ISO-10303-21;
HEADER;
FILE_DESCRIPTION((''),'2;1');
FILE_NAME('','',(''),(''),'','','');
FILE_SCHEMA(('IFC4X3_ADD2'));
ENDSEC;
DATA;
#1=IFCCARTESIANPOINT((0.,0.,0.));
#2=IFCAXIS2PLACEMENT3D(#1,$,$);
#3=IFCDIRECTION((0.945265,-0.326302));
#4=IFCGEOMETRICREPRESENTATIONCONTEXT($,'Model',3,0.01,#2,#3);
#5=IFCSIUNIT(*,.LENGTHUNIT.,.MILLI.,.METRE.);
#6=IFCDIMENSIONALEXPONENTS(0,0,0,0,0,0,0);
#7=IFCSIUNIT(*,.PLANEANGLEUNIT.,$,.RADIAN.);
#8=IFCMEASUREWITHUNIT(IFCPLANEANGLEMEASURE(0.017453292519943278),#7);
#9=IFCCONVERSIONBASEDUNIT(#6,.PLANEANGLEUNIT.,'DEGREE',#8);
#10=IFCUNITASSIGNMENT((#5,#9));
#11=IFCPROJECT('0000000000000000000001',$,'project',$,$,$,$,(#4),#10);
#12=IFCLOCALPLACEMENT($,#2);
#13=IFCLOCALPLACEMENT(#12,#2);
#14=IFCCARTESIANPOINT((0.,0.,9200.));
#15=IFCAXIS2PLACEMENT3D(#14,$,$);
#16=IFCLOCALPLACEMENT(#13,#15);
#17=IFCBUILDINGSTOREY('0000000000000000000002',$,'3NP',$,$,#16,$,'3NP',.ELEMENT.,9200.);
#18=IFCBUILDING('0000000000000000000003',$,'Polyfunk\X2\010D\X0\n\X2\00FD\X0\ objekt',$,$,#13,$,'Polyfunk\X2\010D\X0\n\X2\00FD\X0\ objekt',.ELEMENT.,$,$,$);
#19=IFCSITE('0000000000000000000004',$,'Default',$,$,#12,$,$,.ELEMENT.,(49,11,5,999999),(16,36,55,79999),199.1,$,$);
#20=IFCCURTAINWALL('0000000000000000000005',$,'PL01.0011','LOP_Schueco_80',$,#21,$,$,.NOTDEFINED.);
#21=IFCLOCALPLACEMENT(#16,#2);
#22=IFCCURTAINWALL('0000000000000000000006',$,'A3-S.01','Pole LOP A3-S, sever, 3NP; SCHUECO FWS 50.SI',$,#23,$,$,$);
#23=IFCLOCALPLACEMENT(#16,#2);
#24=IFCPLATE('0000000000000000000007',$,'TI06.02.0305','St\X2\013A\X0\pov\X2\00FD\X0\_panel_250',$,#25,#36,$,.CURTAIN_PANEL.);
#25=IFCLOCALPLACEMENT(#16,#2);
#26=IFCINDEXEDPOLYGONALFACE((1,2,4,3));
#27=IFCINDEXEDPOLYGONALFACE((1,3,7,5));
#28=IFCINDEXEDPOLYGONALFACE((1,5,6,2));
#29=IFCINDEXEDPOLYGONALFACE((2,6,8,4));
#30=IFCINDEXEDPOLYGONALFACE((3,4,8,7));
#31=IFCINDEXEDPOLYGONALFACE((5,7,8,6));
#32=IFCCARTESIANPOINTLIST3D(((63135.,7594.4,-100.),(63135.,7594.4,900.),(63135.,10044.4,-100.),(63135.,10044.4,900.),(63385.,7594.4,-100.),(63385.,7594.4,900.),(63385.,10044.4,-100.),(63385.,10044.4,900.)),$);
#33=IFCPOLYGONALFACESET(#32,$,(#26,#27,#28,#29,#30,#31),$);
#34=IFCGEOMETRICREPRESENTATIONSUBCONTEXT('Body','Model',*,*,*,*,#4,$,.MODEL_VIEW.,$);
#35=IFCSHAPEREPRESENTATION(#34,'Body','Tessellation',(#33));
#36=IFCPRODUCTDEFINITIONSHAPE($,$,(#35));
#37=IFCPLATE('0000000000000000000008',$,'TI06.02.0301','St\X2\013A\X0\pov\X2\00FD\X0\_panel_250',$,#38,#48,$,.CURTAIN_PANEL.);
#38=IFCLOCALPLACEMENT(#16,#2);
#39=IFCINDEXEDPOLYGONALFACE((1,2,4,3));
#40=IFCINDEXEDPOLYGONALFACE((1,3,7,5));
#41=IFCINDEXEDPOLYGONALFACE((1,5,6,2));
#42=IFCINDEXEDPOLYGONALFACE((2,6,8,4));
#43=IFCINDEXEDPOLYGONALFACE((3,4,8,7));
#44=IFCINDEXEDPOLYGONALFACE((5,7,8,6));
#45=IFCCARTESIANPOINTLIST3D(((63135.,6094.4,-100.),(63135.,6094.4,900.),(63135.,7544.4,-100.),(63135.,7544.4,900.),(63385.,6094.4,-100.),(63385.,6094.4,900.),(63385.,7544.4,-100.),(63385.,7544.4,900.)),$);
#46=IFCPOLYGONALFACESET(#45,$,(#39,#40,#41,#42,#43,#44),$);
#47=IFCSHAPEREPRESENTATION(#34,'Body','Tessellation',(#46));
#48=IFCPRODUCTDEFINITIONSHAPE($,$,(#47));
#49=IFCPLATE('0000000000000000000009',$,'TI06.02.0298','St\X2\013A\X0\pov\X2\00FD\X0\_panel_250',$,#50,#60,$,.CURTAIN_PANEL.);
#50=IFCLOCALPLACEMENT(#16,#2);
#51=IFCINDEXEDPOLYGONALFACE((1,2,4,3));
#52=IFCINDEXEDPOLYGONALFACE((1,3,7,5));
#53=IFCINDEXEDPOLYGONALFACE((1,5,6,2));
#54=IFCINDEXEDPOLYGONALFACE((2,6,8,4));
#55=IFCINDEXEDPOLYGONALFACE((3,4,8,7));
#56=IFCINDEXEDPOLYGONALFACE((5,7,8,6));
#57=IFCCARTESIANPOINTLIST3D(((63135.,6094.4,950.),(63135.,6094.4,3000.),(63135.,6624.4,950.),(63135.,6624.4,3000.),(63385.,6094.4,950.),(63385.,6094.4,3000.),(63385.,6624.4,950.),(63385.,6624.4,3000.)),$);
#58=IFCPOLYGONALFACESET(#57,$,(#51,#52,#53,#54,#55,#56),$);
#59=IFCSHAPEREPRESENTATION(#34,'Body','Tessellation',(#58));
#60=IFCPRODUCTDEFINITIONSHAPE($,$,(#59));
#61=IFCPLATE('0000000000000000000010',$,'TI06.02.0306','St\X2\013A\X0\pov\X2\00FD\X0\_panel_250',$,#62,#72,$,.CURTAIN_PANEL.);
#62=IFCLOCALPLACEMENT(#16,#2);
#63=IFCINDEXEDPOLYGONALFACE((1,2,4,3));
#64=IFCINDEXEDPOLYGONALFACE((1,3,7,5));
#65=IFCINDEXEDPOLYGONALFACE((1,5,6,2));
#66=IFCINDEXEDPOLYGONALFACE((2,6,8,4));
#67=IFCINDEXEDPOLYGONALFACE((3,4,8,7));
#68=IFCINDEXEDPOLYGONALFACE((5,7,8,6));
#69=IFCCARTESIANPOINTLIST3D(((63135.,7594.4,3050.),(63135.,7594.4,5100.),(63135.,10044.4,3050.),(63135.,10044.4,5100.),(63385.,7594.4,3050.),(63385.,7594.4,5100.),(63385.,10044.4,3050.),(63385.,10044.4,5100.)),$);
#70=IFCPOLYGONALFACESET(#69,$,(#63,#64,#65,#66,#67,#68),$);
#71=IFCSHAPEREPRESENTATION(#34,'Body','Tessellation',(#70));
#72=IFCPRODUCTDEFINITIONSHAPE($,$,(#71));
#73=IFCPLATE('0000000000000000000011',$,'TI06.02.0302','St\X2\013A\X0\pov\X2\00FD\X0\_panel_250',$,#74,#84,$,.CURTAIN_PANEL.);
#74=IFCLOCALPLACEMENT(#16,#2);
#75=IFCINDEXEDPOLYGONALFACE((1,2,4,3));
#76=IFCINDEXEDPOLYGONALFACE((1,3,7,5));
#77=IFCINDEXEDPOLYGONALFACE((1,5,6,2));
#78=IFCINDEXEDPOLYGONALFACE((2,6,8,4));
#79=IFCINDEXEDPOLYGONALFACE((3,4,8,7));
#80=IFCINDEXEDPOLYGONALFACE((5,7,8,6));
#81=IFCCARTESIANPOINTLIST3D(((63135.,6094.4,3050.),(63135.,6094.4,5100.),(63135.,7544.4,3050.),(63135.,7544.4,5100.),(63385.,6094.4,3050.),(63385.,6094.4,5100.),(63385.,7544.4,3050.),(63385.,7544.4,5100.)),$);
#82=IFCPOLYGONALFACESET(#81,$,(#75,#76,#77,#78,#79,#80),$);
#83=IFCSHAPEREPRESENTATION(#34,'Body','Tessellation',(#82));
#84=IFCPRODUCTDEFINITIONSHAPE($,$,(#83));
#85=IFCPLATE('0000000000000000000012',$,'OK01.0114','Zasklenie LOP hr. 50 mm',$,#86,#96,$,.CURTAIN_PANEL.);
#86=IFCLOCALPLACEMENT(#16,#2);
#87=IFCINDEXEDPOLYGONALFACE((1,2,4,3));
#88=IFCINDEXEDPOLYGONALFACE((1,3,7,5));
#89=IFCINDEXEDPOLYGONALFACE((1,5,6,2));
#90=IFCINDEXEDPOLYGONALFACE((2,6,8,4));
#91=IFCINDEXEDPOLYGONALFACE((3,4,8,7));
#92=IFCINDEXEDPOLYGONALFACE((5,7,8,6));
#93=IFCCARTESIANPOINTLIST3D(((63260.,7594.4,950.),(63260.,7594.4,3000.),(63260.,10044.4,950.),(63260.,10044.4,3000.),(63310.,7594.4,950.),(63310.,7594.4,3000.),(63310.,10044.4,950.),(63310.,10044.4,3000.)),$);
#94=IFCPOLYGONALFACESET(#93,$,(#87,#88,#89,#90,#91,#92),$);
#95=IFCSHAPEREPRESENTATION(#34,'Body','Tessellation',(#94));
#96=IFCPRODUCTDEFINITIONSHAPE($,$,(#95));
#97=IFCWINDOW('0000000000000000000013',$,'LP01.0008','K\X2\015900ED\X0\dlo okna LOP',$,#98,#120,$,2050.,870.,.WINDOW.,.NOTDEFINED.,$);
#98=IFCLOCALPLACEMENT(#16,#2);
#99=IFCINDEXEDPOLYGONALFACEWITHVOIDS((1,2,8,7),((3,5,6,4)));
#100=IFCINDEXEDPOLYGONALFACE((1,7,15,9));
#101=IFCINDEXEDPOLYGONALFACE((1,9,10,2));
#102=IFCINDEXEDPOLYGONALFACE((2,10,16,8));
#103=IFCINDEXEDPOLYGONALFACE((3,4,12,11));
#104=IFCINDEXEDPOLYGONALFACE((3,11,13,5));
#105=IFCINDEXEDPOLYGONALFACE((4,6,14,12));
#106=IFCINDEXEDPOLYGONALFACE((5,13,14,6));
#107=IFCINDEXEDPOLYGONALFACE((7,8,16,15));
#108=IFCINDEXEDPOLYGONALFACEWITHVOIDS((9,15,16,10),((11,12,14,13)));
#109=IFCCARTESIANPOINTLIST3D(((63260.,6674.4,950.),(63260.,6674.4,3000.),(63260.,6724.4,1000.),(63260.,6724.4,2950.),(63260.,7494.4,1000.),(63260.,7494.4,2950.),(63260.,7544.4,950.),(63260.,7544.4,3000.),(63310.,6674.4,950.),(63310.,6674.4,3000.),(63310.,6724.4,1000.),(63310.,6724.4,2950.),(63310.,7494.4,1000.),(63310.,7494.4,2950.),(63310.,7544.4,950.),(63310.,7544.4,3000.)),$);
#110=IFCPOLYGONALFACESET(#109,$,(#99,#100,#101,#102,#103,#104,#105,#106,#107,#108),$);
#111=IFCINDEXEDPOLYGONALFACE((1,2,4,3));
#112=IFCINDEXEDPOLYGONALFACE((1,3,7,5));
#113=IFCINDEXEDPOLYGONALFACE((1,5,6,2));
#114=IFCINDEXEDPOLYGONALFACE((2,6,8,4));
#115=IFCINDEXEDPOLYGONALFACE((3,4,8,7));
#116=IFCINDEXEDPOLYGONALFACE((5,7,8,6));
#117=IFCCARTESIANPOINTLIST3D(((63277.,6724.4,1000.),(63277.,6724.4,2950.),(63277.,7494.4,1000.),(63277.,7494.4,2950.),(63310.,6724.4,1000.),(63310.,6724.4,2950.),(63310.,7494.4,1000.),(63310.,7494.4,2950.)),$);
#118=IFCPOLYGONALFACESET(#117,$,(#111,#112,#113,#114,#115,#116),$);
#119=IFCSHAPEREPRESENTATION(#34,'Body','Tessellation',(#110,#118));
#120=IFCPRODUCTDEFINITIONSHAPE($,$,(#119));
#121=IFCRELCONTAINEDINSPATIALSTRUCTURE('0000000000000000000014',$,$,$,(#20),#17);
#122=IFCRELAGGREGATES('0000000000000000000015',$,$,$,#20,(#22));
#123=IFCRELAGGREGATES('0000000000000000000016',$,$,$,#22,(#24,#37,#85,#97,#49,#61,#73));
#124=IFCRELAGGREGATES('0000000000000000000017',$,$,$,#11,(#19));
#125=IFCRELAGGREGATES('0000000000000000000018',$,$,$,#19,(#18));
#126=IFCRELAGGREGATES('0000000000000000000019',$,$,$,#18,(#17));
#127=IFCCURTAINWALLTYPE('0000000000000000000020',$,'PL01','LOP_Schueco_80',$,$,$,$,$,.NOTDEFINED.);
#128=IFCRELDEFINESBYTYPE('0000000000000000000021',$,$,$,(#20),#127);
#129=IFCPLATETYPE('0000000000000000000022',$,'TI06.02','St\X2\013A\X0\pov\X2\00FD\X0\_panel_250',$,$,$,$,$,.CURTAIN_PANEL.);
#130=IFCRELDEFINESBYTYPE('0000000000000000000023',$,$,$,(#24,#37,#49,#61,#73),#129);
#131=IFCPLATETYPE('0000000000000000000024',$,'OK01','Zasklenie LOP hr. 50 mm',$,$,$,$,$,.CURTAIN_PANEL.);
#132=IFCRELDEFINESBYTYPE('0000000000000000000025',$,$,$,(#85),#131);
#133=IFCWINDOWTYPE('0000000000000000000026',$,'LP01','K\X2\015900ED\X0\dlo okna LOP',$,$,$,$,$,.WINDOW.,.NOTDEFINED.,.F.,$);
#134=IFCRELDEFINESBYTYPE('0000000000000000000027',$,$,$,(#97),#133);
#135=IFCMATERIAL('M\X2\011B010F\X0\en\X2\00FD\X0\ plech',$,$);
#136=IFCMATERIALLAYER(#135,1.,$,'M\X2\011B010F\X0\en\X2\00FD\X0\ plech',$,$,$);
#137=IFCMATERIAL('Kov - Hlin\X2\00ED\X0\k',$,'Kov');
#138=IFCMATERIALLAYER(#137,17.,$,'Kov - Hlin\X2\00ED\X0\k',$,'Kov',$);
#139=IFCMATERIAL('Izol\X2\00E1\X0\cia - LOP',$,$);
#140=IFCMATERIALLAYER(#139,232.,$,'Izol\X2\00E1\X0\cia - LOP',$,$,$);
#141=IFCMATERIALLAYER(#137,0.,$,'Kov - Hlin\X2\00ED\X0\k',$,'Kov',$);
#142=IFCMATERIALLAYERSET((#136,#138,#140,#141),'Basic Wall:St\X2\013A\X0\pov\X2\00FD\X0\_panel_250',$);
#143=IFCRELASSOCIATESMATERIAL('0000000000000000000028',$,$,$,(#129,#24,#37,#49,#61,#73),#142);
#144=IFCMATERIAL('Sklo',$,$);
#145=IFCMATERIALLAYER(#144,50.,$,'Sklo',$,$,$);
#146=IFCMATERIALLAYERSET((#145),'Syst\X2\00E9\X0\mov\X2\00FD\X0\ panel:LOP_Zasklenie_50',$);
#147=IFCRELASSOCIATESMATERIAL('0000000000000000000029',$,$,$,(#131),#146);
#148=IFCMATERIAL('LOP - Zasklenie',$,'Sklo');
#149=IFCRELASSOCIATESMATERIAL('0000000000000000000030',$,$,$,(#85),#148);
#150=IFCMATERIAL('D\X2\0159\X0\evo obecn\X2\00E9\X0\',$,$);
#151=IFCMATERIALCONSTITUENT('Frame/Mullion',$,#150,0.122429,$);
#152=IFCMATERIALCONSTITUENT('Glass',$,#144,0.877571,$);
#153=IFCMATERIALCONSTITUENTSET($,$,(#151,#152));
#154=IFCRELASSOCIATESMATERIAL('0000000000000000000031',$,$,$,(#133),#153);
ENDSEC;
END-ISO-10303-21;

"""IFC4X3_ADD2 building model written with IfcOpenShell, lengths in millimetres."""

from ifc_helpers import new_model, entity, si_unit, converted_unit, direction, frame, frame_2d, origin, origin_2d_with_axis, place, context, subcontext, project, spatial, polyline, rectangle, outline, extrude, source, transform, mapped, material, layer, layer_set, layer_usage, constituent, constituent_set, type_object, type_shapes, element, aggregate, save


model = new_model("IFC4X3_ADD2")

# Units and contexts
model_context = context("Model", 3, precision=0.01, world=origin(), true_north=direction((0.945265, -0.326302)))
body_context = subcontext(model_context, "Body", "Model", "MODEL_VIEW")
ifc_project = project(units=[si_unit("LENGTHUNIT", "METRE", prefix="MILLI"), converted_unit("PLANEANGLEUNIT", "DEGREE", entity("IfcPlaneAngleMeasure", 0.017453292519943278), si_unit("PLANEANGLEUNIT", "RADIAN"), dimensions=[0, 0, 0, 0, 0, 0, 0])], contexts=[model_context])

# Site, building, storey
site_placement = place(None, origin())
site = spatial("IfcSite", under=ifc_project, at=site_placement, Name="Default", CompositionType="ELEMENT", RefLatitude=(49, 11, 5, 999999), RefLongitude=(16, 36, 55, 79999), RefElevation=199.1)
building_placement = place(site_placement, origin())
building = spatial("IfcBuilding", under=site, at=building_placement, Name="Polyfunkčný objekt", LongName="Polyfunkčný objekt", CompositionType="ELEMENT")
storey_placement = place(building_placement, frame((0.0, 0.0, 9200.0)))
storey = spatial("IfcBuildingStorey", under=building, at=storey_placement, Name="3NP", LongName="3NP", CompositionType="ELEMENT", Elevation=9200.0)

# Curtain walls, plates, window
curtain_wall_type = type_object("IfcCurtainWallType", Name="PL01", Description="LOP_Schueco_80", PredefinedType="NOTDEFINED")
curtain_wall_1_placement = place(storey_placement, frame((0.0, 0.0, -9200.0)))
curtain_wall_1 = element("IfcCurtainWall", 1, at=curtain_wall_1_placement, inside=storey, type_object=curtain_wall_type, Name="PL01.0011", Description="LOP_Schueco_80", PredefinedType="NOTDEFINED")
curtain_wall_2 = element("IfcCurtainWall", 2, Name="A3-S.01", Description="Pole LOP A3-S, sever, 3NP; SCHUECO FWS 50.SI")
aggregate(curtain_wall_1, [curtain_wall_2])
ifc_material_1 = material(Name="Měďený plech")
ifc_layer_1 = layer(ifc_material_1, 1.0, Name="Měďený plech")
ifc_material_2 = material(Name="Kov - Hliník", Category="Kov")
ifc_layer_2 = layer(ifc_material_2, 17.0, Name="Kov - Hliník", Category="Kov")
ifc_material_3 = material(Name="Izolácia - LOP")
ifc_layer_3 = layer(ifc_material_3, 232.0, Name="Izolácia - LOP")
ifc_layer_4 = layer(ifc_material_2, 0.0, Name="Kov - Hliník", Category="Kov")
ifc_layer_set_1 = layer_set([ifc_layer_1, ifc_layer_2, ifc_layer_3, ifc_layer_4], Name="Basic Wall:Stĺpový_panel_250")
ifc_layer_usage_1 = layer_usage(ifc_layer_set_1, "AXIS2", "NEGATIVE", 125.0)
plate_type_1 = type_object("IfcPlateType", Name="TI06.02", Description="Stĺpový_panel_250", PredefinedType="CURTAIN_PANEL", material=ifc_layer_set_1)
plate_1_placement = place(storey_placement, frame((63260.0, 10044.4, -100.0), z_axis=(0.0, 0.0, 1.0), x_axis=(0.0, -1.0, 0.0)))
plate_1 = element("IfcPlate", 3, at=plate_1_placement, type_object=plate_type_1, material=ifc_layer_usage_1, Name="TI06.02.0305", Description="Stĺpový_panel_250", PredefinedType="CURTAIN_PANEL", context=body_context, shape_type="SweptSolid", body=[
    extrude(rectangle(XDim=250.0, YDim=2450.0, at=origin_2d_with_axis()), frame((1225.0, 0.0, 0.0), z_axis=(0.0, 0.0, 1.0), x_axis=(0.0, 1.0, 0.0)), (0.0, 0.0, 1.0), 1000.0),
])
ifc_layer_usage_2 = layer_usage(ifc_layer_set_1, "AXIS2", "NEGATIVE", 125.0)
plate_2_placement = place(storey_placement, frame((63260.0, 7544.4, -100.0), z_axis=(0.0, 0.0, 1.0), x_axis=(0.0, -1.0, 0.0)))
plate_2 = element("IfcPlate", 4, at=plate_2_placement, type_object=plate_type_1, material=ifc_layer_usage_2, Name="TI06.02.0301", Description="Stĺpový_panel_250", PredefinedType="CURTAIN_PANEL", context=body_context, shape_type="SweptSolid", body=[
    extrude(rectangle(XDim=250.0, YDim=1450.0, at=frame_2d((0.0, 0.0), x_axis=(1.0, 0.0))), frame((725.0, 0.0, 0.0), z_axis=(0.0, 0.0, 1.0), x_axis=(0.0, 1.0, 0.0)), (0.0, 0.0, 1.0), 1000.0),
])
ifc_layer_usage_3 = layer_usage(ifc_layer_set_1, "AXIS2", "NEGATIVE", 125.0)
plate_3_placement = place(storey_placement, frame((63260.0, 6624.4, 950.0), z_axis=(0.0, 0.0, 1.0), x_axis=(0.0, -1.0, 0.0)))
plate_3 = element("IfcPlate", 5, at=plate_3_placement, type_object=plate_type_1, material=ifc_layer_usage_3, Name="TI06.02.0298", Description="Stĺpový_panel_250", PredefinedType="CURTAIN_PANEL", context=body_context, shape_type="SweptSolid", body=[
    extrude(rectangle(XDim=250.0, YDim=530.0, at=frame_2d((0.0, 0.0), x_axis=(1.0, 0.0))), frame((265.0, 0.0, 0.0), z_axis=(0.0, 0.0, 1.0), x_axis=(0.0, 1.0, 0.0)), (0.0, 0.0, 1.0), 2050.0),
])
ifc_layer_usage_4 = layer_usage(ifc_layer_set_1, "AXIS2", "NEGATIVE", 125.0)
plate_4_placement = place(storey_placement, frame((63260.0, 10044.4, 3050.0), z_axis=(0.0, 0.0, 1.0), x_axis=(0.0, -1.0, 0.0)))
plate_4 = element("IfcPlate", 6, at=plate_4_placement, type_object=plate_type_1, material=ifc_layer_usage_4, Name="TI06.02.0306", Description="Stĺpový_panel_250", PredefinedType="CURTAIN_PANEL", context=body_context, shape_type="SweptSolid", body=[
    extrude(rectangle(XDim=250.0, YDim=2450.0, at=frame_2d((0.0, 0.0), x_axis=(1.0, 0.0))), frame((1225.0, 0.0, 0.0), z_axis=(0.0, 0.0, 1.0), x_axis=(0.0, 1.0, 0.0)), (0.0, 0.0, 1.0), 2050.0),
])
ifc_layer_usage_5 = layer_usage(ifc_layer_set_1, "AXIS2", "NEGATIVE", 125.0)
plate_5_placement = place(storey_placement, frame((63260.0, 7544.4, 3050.0), z_axis=(0.0, 0.0, 1.0), x_axis=(0.0, -1.0, 0.0)))
plate_5 = element("IfcPlate", 7, at=plate_5_placement, type_object=plate_type_1, material=ifc_layer_usage_5, Name="TI06.02.0302", Description="Stĺpový_panel_250", PredefinedType="CURTAIN_PANEL", context=body_context, shape_type="SweptSolid", body=[
    extrude(rectangle(XDim=250.0, YDim=1450.0, at=frame_2d((0.0, 0.0), x_axis=(1.0, 0.0))), frame((725.0, 0.0, 0.0), z_axis=(0.0, 0.0, 1.0), x_axis=(0.0, 1.0, 0.0)), (0.0, 0.0, 1.0), 2050.0),
])
ifc_material_4 = material(Name="LOP - Zasklenie", Category="Sklo")
ifc_material_5 = material(Name="Sklo")
ifc_layer_5 = layer(ifc_material_5, 50.0, Name="Sklo")
ifc_layer_set_2 = layer_set([ifc_layer_5], Name="Systémový panel:LOP_Zasklenie_50")
plate_type_2 = type_object("IfcPlateType", Name="OK01", Description="Zasklenie LOP hr. 50 mm", PredefinedType="CURTAIN_PANEL", material=ifc_layer_set_2)
shared_shape_1 = source(origin(), body_context, "Body", "SweptSolid", [
    extrude(rectangle(XDim=50.0, YDim=2450.0, at=origin_2d_with_axis()), frame((0.0, 25.0, 0.0), z_axis=(0.0, 0.0, 1.0), x_axis=(0.0, 1.0, 0.0)), (0.0, 0.0, 1.0), 2050.0),
])
type_shapes(plate_type_2, [shared_shape_1])
plate_6_placement = place(curtain_wall_1_placement, frame((63260.0, 8819.4, 10150.0), z_axis=(0.0, 0.0, 1.0), x_axis=(0.0, -1.0, 0.0)))
plate_6 = element("IfcPlate", 8, at=plate_6_placement, type_object=plate_type_2, material=ifc_material_4, Name="OK01.0114", Description="Zasklenie LOP hr. 50 mm", PredefinedType="CURTAIN_PANEL", context=body_context, shape_type="MappedRepresentation", body=[
    mapped(shared_shape_1, transform((0.0, 0.0, 0.0), scale=1.0)),
])
ifc_material_6 = material(Name="Dřevo obecné")
ifc_constituent_1 = constituent(ifc_material_6, Name="Frame/Mullion", fraction=0.122429)
ifc_constituent_2 = constituent(ifc_material_5, Name="Glass", fraction=0.877571)
ifc_constituent_set = constituent_set(constituents=[ifc_constituent_1, ifc_constituent_2])
window_type = type_object("IfcWindowType", Name="LP01", Description="Křídlo okna LOP", ParameterTakesPrecedence=False, PartitioningType="NOTDEFINED", PredefinedType="WINDOW", material=ifc_constituent_set)
shared_shape_2 = source(origin(), body_context, "Body", "SweptSolid", [
    extrude(outline(polyline([(-1025.0, -435.0), (1025.0, -435.0), (1025.0, 435.0), (-1025.0, 435.0), (-1025.0, -435.0)]), holes=[polyline([(-975.0, -385.0), (-975.0, 385.0), (975.0, 385.0), (975.0, -385.0), (-975.0, -385.0)])]), frame((0.0, 0.0, 1025.0), z_axis=(0.0, 1.0, 0.0), x_axis=(0.0, 0.0, -1.0)), (0.0, 0.0, 1.0), 50.0),
    extrude(rectangle(XDim=33.0, YDim=770.0, at=origin_2d_with_axis()), frame((0.0, 33.5, 50.0), z_axis=(0.0, 0.0, 1.0), x_axis=(0.0, -1.0, 0.0)), (0.0, 0.0, 1.0), 1950.0),
])
type_shapes(window_type, [shared_shape_2])
window_placement = place(curtain_wall_1_placement, frame((63260.0, 7109.4, 10150.0), z_axis=(0.0, 0.0, 1.0), x_axis=(0.0, -1.0, 0.0)))
window = element("IfcWindow", 9, at=window_placement, type_object=window_type, Name="LP01.0008", Description="Křídlo okna LOP", OverallHeight=2050.0, OverallWidth=870.0, PartitioningType="NOTDEFINED", PredefinedType="WINDOW", context=body_context, shape_type="MappedRepresentation", body=[
    mapped(shared_shape_2, transform((0.0, 0.0, 0.0), scale=1.0)),
])
aggregate(curtain_wall_2, [plate_1, plate_2, plate_6, window, plate_3, plate_4, plate_5])

save(model, "model.ifc")
